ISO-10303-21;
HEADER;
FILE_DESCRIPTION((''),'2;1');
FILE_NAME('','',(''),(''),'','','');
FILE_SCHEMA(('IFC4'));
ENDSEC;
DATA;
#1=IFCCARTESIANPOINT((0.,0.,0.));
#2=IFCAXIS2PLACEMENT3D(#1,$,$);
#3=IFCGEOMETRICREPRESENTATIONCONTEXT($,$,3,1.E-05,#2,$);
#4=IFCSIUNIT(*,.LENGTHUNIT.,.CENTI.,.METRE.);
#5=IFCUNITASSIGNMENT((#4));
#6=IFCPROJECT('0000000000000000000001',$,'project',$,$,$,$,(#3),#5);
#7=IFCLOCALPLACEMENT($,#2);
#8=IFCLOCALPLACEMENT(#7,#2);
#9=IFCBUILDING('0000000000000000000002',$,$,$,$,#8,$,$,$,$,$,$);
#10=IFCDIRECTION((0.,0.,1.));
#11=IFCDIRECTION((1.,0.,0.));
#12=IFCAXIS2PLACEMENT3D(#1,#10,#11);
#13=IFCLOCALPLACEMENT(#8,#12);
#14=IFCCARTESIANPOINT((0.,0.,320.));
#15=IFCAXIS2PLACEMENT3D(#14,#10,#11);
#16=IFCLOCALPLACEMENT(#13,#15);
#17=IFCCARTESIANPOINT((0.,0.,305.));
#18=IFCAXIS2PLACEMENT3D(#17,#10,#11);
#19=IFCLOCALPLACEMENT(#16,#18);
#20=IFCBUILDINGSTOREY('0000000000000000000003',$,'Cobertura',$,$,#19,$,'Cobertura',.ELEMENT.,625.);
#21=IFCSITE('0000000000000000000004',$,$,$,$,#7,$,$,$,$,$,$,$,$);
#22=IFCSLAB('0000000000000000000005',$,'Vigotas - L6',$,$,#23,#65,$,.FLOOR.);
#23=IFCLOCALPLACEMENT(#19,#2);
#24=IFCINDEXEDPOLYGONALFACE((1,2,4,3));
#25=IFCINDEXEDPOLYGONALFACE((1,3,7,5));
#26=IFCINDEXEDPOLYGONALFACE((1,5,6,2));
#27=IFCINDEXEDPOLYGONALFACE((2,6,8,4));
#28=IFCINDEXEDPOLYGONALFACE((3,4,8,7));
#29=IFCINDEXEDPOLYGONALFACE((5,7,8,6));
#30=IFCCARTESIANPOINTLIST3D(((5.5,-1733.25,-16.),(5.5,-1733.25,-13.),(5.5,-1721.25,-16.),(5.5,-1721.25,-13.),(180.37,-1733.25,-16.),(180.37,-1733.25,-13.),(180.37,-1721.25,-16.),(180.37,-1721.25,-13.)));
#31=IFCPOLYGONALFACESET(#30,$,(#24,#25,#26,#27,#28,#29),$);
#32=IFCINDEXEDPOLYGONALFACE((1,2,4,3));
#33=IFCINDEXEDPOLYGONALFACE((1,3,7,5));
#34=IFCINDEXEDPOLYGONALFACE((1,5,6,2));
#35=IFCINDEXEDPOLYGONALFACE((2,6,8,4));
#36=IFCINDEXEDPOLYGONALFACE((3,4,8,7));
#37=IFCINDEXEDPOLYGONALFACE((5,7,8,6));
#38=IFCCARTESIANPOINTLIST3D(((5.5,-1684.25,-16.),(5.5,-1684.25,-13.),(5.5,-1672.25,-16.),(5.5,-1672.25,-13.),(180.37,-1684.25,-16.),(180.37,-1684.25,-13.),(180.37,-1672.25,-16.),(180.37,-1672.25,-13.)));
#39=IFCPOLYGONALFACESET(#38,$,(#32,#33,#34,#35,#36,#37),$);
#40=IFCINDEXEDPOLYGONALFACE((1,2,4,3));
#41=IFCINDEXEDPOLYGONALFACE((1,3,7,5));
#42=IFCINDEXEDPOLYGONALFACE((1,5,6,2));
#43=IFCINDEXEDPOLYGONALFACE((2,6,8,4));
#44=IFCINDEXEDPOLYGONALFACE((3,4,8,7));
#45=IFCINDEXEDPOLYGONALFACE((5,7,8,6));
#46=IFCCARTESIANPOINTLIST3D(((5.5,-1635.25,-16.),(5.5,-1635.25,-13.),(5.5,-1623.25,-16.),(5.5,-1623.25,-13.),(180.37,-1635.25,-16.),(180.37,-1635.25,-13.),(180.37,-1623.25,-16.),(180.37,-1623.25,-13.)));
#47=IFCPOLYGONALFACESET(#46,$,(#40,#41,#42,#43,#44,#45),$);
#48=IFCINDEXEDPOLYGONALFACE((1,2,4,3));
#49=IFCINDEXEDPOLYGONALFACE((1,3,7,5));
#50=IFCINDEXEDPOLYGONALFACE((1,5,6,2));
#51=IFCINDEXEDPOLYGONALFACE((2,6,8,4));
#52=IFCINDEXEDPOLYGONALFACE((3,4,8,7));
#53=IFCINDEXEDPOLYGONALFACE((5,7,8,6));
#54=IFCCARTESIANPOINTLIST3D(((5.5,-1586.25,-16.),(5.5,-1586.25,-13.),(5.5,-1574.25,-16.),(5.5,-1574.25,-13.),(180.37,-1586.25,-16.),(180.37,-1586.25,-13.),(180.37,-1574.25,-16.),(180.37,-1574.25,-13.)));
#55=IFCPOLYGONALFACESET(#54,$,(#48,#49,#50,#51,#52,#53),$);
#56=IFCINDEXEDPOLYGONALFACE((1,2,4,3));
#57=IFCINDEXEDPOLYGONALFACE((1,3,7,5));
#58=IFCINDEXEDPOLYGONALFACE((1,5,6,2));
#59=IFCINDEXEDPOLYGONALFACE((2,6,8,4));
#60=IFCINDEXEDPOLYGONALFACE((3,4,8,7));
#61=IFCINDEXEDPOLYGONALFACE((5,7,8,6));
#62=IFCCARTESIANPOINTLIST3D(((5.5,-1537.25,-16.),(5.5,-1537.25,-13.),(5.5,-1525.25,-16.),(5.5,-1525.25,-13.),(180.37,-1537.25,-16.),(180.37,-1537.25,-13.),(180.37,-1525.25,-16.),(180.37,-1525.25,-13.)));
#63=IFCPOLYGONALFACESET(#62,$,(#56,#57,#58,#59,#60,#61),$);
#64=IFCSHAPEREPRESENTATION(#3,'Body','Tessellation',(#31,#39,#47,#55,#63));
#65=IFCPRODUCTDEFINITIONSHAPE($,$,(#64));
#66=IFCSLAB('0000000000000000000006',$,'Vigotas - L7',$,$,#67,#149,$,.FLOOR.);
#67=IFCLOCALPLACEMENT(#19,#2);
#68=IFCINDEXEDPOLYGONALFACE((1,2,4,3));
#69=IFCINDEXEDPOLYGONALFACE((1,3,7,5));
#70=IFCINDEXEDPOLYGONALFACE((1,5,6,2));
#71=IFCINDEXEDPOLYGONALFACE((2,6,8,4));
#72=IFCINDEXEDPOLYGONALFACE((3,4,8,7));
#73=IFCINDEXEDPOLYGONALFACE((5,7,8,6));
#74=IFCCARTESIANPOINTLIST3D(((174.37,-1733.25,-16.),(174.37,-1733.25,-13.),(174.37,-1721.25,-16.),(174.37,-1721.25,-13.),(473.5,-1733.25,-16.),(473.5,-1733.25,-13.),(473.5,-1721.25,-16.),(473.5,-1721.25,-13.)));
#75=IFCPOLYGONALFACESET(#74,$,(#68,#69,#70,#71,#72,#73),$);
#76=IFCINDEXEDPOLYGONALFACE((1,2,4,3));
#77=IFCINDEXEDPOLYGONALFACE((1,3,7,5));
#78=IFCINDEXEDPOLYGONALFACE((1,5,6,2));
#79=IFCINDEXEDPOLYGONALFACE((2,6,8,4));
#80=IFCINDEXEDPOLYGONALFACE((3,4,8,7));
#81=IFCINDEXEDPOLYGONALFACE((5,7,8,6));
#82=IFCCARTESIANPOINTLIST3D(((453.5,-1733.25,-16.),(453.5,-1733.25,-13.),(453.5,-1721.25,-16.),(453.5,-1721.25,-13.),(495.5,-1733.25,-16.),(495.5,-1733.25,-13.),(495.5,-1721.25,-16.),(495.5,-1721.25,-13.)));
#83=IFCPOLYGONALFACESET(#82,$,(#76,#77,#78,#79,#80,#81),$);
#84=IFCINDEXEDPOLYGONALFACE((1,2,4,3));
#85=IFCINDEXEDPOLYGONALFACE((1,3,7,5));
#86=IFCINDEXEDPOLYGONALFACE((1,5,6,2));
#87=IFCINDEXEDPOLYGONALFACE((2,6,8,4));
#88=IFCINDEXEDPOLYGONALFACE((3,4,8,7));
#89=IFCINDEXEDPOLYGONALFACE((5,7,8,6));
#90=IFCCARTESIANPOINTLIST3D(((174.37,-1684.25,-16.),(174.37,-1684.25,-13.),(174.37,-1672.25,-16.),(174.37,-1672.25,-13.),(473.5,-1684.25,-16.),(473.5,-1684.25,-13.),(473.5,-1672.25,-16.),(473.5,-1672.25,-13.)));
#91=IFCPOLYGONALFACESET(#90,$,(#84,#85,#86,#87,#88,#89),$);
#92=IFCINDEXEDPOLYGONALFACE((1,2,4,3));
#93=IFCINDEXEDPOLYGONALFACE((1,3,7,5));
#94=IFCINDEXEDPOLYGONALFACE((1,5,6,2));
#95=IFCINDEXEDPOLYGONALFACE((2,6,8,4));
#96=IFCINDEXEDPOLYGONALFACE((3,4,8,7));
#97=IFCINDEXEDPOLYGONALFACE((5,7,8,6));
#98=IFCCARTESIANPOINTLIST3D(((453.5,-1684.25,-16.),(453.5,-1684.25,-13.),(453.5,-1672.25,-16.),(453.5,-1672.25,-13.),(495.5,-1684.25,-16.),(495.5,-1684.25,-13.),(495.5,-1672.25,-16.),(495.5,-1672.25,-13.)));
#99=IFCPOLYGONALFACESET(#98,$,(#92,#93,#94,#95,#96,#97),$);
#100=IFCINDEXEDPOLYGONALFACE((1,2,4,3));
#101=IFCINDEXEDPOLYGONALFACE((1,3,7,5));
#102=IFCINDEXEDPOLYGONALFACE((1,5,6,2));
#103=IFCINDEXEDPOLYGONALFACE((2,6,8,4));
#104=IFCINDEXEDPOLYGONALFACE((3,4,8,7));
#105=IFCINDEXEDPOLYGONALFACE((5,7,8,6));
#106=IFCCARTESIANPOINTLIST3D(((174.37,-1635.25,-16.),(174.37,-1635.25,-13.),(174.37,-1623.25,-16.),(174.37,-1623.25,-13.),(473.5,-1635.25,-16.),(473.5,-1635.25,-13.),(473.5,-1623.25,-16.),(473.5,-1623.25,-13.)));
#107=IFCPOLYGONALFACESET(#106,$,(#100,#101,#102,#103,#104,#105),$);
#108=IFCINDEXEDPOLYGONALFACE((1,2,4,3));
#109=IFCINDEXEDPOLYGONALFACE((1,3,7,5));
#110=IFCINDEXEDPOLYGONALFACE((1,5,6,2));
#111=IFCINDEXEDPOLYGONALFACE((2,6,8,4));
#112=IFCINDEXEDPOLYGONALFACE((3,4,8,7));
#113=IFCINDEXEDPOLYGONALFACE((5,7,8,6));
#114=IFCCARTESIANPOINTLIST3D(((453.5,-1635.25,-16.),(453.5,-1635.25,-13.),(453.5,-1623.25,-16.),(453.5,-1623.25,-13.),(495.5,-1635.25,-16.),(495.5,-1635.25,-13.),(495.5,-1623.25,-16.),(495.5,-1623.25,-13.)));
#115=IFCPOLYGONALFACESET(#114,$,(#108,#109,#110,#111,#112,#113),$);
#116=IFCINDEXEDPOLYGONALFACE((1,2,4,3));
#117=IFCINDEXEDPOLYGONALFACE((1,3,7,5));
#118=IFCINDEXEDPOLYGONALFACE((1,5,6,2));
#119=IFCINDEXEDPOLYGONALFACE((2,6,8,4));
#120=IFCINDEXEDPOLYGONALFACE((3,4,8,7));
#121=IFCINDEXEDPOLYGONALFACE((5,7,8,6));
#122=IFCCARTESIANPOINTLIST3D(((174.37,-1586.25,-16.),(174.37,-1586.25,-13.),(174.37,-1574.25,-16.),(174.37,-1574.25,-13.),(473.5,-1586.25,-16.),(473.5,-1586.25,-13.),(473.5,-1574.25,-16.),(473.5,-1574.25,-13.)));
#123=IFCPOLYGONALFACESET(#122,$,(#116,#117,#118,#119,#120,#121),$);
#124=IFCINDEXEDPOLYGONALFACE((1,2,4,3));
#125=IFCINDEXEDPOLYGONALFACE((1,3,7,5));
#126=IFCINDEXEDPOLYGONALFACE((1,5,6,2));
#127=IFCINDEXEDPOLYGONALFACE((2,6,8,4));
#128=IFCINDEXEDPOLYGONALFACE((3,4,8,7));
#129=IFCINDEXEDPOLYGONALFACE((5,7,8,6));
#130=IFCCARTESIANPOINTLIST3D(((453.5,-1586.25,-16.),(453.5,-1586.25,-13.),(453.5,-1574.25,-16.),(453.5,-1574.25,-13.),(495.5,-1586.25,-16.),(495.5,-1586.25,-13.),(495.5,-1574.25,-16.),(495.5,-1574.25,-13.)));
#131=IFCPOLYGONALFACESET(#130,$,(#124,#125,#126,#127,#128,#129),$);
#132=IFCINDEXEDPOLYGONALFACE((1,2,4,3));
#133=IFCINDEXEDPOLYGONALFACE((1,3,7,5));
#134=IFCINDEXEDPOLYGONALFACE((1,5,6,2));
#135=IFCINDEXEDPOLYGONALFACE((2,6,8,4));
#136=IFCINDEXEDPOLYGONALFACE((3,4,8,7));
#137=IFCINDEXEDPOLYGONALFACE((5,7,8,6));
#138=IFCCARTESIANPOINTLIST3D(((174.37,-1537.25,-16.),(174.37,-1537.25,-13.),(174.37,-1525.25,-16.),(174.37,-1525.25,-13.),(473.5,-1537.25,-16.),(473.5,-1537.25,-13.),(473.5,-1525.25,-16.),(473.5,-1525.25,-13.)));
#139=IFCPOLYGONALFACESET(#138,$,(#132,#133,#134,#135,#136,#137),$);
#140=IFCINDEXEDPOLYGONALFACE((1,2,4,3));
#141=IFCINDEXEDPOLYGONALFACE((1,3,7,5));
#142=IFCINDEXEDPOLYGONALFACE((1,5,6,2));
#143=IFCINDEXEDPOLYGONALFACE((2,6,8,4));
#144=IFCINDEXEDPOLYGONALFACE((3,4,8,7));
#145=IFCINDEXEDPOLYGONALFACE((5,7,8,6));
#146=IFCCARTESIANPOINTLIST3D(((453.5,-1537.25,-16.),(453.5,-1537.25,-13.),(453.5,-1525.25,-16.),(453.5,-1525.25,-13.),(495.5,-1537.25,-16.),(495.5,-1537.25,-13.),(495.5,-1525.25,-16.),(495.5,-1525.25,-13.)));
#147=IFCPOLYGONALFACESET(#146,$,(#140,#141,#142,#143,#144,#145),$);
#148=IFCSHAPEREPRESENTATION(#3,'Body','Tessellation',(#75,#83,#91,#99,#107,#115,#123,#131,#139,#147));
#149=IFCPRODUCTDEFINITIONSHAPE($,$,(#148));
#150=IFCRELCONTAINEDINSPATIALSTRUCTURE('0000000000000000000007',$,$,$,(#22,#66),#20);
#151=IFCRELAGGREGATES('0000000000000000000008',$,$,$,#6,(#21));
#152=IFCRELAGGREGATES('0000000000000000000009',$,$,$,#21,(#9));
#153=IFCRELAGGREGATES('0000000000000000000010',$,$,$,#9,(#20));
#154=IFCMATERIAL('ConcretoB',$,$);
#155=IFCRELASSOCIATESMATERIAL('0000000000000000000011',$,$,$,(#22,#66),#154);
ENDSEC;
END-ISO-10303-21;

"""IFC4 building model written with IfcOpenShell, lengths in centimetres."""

from ifc_helpers import new_model, si_unit, frame, origin, origin_with_axes, place, context, project, spatial, polyline, outline, extrude, material, element, save


model = new_model("IFC4")

# Units and contexts
context_of_model = context(None, 3, precision=1e-05, world=origin())
ifc_project = project(units=[si_unit("LENGTHUNIT", "METRE", prefix="CENTI")], contexts=[context_of_model])

# Site, building, storey
site_placement = place(None, origin())
site = spatial("IfcSite", under=ifc_project, at=site_placement)
building_placement = place(site_placement, origin())
building = spatial("IfcBuilding", under=site, at=building_placement)
placement_1 = place(building_placement, origin_with_axes())
placement_2 = place(placement_1, frame((0.0, 0.0, 320.0), z_axis=(0.0, 0.0, 1.0), x_axis=(1.0, 0.0, 0.0)))
storey_placement = place(placement_2, frame((0.0, 0.0, 305.0), z_axis=(0.0, 0.0, 1.0), x_axis=(1.0, 0.0, 0.0)))
storey = spatial("IfcBuildingStorey", under=building, at=storey_placement, Name="Cobertura", LongName="Cobertura", CompositionType="ELEMENT", Elevation=625.0)

# Shared definitions
ifc_material = material(Name="ConcretoB")

# Slabs
slab_1_placement = place(storey_placement, frame((92.94, -1629.25, -13.0), z_axis=(0.0, 0.0, 1.0), x_axis=(1.0, 0.0, 0.0)))
element("IfcSlab", 1, at=slab_1_placement, inside=storey, material=ifc_material, Name="Vigotas - L6", PredefinedType="FLOOR", context=context_of_model, shape_type="SolidModel", body=[
    extrude(outline(polyline([(6.0, 1.5), (-6.0, 1.5), (-6.0, -1.5), (6.0, -1.5), (6.0, 1.5), (6.0, 1.5)])), frame((-87.44, -98.0, -1.5), z_axis=(1.0, 0.0, 0.0), x_axis=(0.0, -1.0, 0.0)), (0.0, 0.0, 1.0), 174.87),
    extrude(outline(polyline([(6.0, 1.5), (-6.0, 1.5), (-6.0, -1.5), (6.0, -1.5), (6.0, 1.5), (6.0, 1.5)])), frame((-87.44, -49.0, -1.5), z_axis=(1.0, 0.0, 0.0), x_axis=(0.0, -1.0, 0.0)), (0.0, 0.0, 1.0), 174.87),
    extrude(outline(polyline([(6.0, 1.5), (-6.0, 1.5), (-6.0, -1.5), (6.0, -1.5), (6.0, 1.5), (6.0, 1.5)])), frame((-87.44, 0.0, -1.5), z_axis=(1.0, 0.0, 0.0), x_axis=(0.0, -1.0, 0.0)), (0.0, 0.0, 1.0), 174.87),
    extrude(outline(polyline([(6.0, 1.5), (-6.0, 1.5), (-6.0, -1.5), (6.0, -1.5), (6.0, 1.5), (6.0, 1.5)])), frame((-87.44, 49.0, -1.5), z_axis=(1.0, 0.0, 0.0), x_axis=(0.0, -1.0, 0.0)), (0.0, 0.0, 1.0), 174.87),
    extrude(outline(polyline([(6.0, 1.5), (-6.0, 1.5), (-6.0, -1.5), (6.0, -1.5), (6.0, 1.5), (6.0, 1.5)])), frame((-87.44, 98.0, -1.5), z_axis=(1.0, 0.0, 0.0), x_axis=(0.0, -1.0, 0.0)), (0.0, 0.0, 1.0), 174.87),
])
slab_2_placement = place(storey_placement, frame((334.94, -1629.25, -13.0), z_axis=(0.0, 0.0, 1.0), x_axis=(1.0, 0.0, 0.0)))
element("IfcSlab", 2, at=slab_2_placement, inside=storey, material=ifc_material, Name="Vigotas - L7", PredefinedType="FLOOR", context=context_of_model, shape_type="SolidModel", body=[
    extrude(outline(polyline([(6.0, 1.5), (-6.0, 1.5), (-6.0, -1.5), (6.0, -1.5), (6.0, 1.5), (6.0, 1.5)])), frame((-160.56, -98.0, -1.5), z_axis=(1.0, 0.0, 0.0), x_axis=(0.0, -1.0, 0.0)), (0.0, 0.0, 1.0), 299.13),
    extrude(outline(polyline([(6.0, 1.5), (-6.0, 1.5), (-6.0, -1.5), (6.0, -1.5), (6.0, 1.5), (6.0, 1.5)])), frame((118.56, -98.0, -1.5), z_axis=(1.0, 0.0, 0.0), x_axis=(0.0, -1.0, 0.0)), (0.0, 0.0, 1.0), 42.0),
    extrude(outline(polyline([(6.0, 1.5), (-6.0, 1.5), (-6.0, -1.5), (6.0, -1.5), (6.0, 1.5), (6.0, 1.5)])), frame((-160.56, -49.0, -1.5), z_axis=(1.0, 0.0, 0.0), x_axis=(0.0, -1.0, 0.0)), (0.0, 0.0, 1.0), 299.13),
    extrude(outline(polyline([(6.0, 1.5), (-6.0, 1.5), (-6.0, -1.5), (6.0, -1.5), (6.0, 1.5), (6.0, 1.5)])), frame((118.56, -49.0, -1.5), z_axis=(1.0, 0.0, 0.0), x_axis=(0.0, -1.0, 0.0)), (0.0, 0.0, 1.0), 42.0),
    extrude(outline(polyline([(6.0, 1.5), (-6.0, 1.5), (-6.0, -1.5), (6.0, -1.5), (6.0, 1.5), (6.0, 1.5)])), frame((-160.56, 0.0, -1.5), z_axis=(1.0, 0.0, 0.0), x_axis=(0.0, -1.0, 0.0)), (0.0, 0.0, 1.0), 299.13),
    extrude(outline(polyline([(6.0, 1.5), (-6.0, 1.5), (-6.0, -1.5), (6.0, -1.5), (6.0, 1.5), (6.0, 1.5)])), frame((118.56, 0.0, -1.5), z_axis=(1.0, 0.0, 0.0), x_axis=(0.0, -1.0, 0.0)), (0.0, 0.0, 1.0), 42.0),
    extrude(outline(polyline([(6.0, 1.5), (-6.0, 1.5), (-6.0, -1.5), (6.0, -1.5), (6.0, 1.5), (6.0, 1.5)])), frame((-160.56, 49.0, -1.5), z_axis=(1.0, 0.0, 0.0), x_axis=(0.0, -1.0, 0.0)), (0.0, 0.0, 1.0), 299.13),
    extrude(outline(polyline([(6.0, 1.5), (-6.0, 1.5), (-6.0, -1.5), (6.0, -1.5), (6.0, 1.5), (6.0, 1.5)])), frame((118.56, 49.0, -1.5), z_axis=(1.0, 0.0, 0.0), x_axis=(0.0, -1.0, 0.0)), (0.0, 0.0, 1.0), 42.0),
    extrude(outline(polyline([(6.0, 1.5), (-6.0, 1.5), (-6.0, -1.5), (6.0, -1.5), (6.0, 1.5), (6.0, 1.5)])), frame((-160.56, 98.0, -1.5), z_axis=(1.0, 0.0, 0.0), x_axis=(0.0, -1.0, 0.0)), (0.0, 0.0, 1.0), 299.13),
    extrude(outline(polyline([(6.0, 1.5), (-6.0, 1.5), (-6.0, -1.5), (6.0, -1.5), (6.0, 1.5), (6.0, 1.5)])), frame((118.56, 98.0, -1.5), z_axis=(1.0, 0.0, 0.0), x_axis=(0.0, -1.0, 0.0)), (0.0, 0.0, 1.0), 42.0),
])

save(model, "model.ifc")
